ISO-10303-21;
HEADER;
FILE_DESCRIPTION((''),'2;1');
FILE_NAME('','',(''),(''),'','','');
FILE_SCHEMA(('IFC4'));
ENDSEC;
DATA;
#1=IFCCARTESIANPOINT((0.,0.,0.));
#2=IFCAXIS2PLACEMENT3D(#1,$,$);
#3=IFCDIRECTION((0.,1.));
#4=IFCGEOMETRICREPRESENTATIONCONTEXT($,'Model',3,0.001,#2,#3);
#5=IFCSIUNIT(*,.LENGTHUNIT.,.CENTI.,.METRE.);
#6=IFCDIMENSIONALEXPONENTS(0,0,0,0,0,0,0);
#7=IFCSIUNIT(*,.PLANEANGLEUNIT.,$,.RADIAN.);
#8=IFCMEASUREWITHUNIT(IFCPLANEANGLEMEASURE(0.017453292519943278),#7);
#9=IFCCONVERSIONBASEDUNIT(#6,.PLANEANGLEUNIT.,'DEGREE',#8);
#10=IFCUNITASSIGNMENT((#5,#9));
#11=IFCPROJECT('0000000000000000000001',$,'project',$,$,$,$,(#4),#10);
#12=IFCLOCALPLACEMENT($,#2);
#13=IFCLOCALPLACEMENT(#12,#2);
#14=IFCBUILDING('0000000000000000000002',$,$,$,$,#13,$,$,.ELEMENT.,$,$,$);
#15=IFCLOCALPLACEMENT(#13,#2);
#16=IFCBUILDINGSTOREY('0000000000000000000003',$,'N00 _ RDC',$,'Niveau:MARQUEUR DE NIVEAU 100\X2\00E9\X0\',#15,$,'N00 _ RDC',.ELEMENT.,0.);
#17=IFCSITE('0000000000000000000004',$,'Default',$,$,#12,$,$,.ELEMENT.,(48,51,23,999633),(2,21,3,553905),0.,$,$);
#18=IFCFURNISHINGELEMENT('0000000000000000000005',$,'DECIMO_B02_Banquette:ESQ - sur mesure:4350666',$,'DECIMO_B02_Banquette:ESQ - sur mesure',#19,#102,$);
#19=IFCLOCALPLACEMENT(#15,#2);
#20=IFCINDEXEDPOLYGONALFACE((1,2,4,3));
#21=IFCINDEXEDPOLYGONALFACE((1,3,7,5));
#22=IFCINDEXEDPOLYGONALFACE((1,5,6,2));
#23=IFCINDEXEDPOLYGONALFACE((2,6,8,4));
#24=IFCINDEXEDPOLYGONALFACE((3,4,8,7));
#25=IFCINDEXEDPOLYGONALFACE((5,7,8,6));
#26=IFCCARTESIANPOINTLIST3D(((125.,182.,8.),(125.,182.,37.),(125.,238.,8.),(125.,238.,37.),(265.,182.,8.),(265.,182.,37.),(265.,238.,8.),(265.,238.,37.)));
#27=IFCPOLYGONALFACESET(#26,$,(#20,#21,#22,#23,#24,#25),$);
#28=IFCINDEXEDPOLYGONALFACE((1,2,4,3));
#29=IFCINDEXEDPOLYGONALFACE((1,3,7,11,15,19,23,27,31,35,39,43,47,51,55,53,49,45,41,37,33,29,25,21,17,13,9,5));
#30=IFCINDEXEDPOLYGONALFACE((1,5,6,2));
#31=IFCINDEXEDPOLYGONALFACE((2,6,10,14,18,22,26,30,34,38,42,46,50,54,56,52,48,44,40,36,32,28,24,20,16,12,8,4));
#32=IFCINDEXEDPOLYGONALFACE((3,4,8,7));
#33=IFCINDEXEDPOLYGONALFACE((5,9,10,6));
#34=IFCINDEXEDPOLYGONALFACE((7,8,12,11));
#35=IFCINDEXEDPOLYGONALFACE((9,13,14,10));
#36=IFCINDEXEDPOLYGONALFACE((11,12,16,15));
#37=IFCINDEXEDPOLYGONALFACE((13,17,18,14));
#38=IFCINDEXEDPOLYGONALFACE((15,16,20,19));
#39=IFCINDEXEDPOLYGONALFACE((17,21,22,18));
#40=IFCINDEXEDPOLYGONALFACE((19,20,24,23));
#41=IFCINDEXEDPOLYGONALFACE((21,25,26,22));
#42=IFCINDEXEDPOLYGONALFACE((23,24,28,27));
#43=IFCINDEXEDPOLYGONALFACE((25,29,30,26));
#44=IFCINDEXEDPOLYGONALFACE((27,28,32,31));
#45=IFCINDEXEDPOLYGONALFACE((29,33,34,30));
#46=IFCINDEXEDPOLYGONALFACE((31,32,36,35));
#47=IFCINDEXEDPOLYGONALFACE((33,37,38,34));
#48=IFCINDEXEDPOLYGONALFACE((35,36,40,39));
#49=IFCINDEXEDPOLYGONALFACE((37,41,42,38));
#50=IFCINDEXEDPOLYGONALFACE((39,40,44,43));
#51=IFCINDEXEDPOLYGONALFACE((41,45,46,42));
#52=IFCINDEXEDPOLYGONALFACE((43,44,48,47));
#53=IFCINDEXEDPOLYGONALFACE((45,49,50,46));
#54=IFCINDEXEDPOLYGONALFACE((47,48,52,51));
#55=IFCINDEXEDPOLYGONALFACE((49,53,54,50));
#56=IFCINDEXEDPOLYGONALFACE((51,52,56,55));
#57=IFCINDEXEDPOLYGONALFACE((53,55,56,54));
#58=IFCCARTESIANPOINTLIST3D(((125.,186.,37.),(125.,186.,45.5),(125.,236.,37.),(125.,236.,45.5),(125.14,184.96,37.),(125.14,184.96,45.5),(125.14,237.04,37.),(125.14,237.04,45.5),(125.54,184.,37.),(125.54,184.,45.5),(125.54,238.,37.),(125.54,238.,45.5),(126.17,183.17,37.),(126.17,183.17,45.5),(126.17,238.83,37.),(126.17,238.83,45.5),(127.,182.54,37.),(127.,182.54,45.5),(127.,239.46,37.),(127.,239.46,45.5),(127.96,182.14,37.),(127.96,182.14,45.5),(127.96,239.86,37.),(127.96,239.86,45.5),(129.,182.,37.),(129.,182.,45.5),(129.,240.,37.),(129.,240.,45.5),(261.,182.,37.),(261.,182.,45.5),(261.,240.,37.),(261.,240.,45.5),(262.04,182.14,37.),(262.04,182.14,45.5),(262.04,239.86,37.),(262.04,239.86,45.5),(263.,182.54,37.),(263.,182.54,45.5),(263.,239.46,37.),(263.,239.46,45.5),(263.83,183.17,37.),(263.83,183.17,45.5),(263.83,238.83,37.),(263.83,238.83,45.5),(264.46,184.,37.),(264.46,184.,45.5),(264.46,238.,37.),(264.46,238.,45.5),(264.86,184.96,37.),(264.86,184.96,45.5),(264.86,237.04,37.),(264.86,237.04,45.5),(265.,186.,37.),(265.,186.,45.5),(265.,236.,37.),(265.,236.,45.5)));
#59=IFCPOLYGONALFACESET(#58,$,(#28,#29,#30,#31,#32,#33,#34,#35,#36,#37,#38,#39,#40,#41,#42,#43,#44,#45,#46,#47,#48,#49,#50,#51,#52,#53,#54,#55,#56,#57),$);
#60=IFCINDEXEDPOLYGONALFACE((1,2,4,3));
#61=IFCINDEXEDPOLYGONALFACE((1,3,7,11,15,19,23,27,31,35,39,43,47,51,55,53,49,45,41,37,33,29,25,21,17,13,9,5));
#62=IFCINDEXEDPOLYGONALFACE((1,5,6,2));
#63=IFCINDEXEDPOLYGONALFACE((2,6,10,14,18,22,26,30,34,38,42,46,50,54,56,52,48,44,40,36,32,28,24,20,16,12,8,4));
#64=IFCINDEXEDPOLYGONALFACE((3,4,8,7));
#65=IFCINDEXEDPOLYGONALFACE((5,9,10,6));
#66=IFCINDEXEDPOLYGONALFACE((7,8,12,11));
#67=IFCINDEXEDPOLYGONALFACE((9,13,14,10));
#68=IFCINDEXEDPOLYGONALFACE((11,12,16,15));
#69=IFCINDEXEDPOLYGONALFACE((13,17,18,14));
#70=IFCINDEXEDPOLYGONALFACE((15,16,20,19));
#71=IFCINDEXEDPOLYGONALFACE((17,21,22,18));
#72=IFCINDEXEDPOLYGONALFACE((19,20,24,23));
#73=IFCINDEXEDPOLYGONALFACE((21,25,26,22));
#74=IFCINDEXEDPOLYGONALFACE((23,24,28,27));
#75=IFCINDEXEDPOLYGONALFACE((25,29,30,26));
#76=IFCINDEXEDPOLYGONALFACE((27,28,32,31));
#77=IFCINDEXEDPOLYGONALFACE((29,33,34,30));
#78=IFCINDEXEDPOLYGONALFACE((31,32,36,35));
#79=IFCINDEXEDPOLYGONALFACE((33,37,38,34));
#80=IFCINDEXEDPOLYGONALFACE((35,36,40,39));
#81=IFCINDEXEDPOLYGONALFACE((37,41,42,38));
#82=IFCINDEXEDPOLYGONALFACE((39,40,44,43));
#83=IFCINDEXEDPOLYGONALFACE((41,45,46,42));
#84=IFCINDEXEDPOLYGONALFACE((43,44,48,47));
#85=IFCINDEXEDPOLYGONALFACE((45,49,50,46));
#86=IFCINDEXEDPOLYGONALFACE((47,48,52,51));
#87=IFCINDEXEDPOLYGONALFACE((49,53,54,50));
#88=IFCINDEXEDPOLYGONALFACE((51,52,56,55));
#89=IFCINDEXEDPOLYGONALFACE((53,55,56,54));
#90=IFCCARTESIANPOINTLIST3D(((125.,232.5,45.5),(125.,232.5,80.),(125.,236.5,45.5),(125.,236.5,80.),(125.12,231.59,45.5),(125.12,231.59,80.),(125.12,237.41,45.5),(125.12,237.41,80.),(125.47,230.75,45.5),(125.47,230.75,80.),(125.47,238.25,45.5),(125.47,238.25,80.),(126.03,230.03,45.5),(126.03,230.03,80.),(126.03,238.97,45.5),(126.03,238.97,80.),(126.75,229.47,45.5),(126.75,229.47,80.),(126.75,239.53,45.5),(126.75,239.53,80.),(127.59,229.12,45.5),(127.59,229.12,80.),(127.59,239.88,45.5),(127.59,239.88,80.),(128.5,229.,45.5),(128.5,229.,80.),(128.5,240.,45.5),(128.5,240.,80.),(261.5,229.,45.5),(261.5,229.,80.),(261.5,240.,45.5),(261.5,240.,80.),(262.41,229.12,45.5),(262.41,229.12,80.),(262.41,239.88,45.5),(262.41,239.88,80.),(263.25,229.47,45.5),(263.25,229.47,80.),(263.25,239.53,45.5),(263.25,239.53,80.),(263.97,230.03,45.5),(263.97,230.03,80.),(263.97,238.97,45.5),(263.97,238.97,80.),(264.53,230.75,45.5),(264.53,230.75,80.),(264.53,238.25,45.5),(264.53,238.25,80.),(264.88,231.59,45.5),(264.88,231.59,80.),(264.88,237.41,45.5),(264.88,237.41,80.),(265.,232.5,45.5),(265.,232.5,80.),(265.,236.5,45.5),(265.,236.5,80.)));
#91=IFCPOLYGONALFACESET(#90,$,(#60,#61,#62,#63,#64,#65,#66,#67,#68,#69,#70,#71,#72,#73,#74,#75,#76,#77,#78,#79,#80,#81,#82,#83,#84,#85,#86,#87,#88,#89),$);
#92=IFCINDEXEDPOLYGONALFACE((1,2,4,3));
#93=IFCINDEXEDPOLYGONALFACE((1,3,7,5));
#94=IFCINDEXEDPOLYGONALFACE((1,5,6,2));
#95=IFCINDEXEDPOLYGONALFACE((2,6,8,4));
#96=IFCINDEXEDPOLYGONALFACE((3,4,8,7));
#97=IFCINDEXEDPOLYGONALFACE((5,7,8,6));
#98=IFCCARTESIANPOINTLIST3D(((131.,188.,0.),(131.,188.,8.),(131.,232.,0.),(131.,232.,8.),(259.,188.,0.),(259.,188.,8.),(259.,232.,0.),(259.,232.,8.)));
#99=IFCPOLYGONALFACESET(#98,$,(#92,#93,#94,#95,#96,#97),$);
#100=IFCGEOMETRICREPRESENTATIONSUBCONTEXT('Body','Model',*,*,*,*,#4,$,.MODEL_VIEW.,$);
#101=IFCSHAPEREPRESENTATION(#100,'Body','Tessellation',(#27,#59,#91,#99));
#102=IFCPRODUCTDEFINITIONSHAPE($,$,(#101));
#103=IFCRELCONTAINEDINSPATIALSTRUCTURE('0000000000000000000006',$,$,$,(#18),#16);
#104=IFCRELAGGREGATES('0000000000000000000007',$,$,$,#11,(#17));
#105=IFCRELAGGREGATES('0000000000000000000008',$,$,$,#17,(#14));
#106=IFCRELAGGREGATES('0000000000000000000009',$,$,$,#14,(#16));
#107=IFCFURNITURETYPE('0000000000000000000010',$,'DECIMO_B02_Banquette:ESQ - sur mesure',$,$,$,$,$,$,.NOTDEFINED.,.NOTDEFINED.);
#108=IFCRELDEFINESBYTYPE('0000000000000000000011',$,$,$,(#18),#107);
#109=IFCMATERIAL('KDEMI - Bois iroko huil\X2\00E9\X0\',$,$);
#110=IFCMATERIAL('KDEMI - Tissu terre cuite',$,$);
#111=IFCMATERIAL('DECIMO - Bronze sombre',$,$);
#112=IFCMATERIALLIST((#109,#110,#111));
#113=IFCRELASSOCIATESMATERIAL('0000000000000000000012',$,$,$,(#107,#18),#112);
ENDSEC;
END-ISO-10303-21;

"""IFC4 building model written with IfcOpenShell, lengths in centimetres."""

from ifc_helpers import new_model, entity, si_unit, converted_unit, direction, frame, frame_2d, origin, origin_2d_with_axis, place, context, subcontext, project, spatial, polyline, circle_curve, parameter, trimmed, segment, composite_curve, rectangle, outline, extrude, source, transform, mapped, material, material_list, type_object, type_shapes, element, save


model = new_model("IFC4")

# Units and contexts
model_context = context("Model", 3, precision=0.001, world=origin(), true_north=direction((0.0, 1.0)))
body_context = subcontext(model_context, "Body", "Model", "MODEL_VIEW")
ifc_project = project(units=[si_unit("LENGTHUNIT", "METRE", prefix="CENTI"), converted_unit("PLANEANGLEUNIT", "DEGREE", entity("IfcPlaneAngleMeasure", 0.017453292519943278), si_unit("PLANEANGLEUNIT", "RADIAN"), dimensions=[0, 0, 0, 0, 0, 0, 0])], contexts=[model_context])

# Site, building, storey
site_placement = place(None, origin())
site = spatial("IfcSite", under=ifc_project, at=site_placement, Name="Default", CompositionType="ELEMENT", RefLatitude=(48, 51, 23, 999633), RefLongitude=(2, 21, 3, 553905), RefElevation=0.0)
building_placement = place(site_placement, origin())
building = spatial("IfcBuilding", under=site, at=building_placement, CompositionType="ELEMENT")
storey_placement = place(building_placement, origin())
storey = spatial("IfcBuildingStorey", under=building, at=storey_placement, Name="N00 _ RDC", ObjectType="Niveau:MARQUEUR DE NIVEAU 100é", LongName="N00 _ RDC", CompositionType="ELEMENT", Elevation=0.0)

# Furnishing element
ifc_material_1 = material(Name="KDEMI - Bois iroko huilé")
ifc_material_2 = material(Name="DECIMO - Bronze sombre")
ifc_material_3 = material(Name="KDEMI - Tissu terre cuite")
ifc_material_list_1 = material_list([ifc_material_1, ifc_material_3, ifc_material_2])
furniture_type_1 = type_object("IfcFurnitureType", Name="DECIMO_B02_Banquette:ESQ - sur mesure", AssemblyPlace="NOTDEFINED", material=ifc_material_list_1)
shared_shape_1 = source(origin(), body_context, "Body", "SweptSolid", [
    extrude(rectangle(XDim=140.0, YDim=56.0, at=origin_2d_with_axis()), frame((70.0, 28.0, 8.0)), (0.0, 0.0, 1.0), 29.0),
    extrude(outline(composite_curve([segment(polyline([(-66.0, -29.0), (66.0, -29.0)]), True, "CONTINUOUS"), segment(trimmed(circle_curve(frame_2d((66.0, -25.0), x_axis=(1.0, 0.0)), 4.0), [parameter(270.0)], [parameter(0.0)], True, "PARAMETER"), True, "CONTINUOUS"), segment(polyline([(70.0, -25.0), (70.0, 25.0)]), True, "CONTINUOUS"), segment(trimmed(circle_curve(frame_2d((66.0, 25.0), x_axis=(1.0, 0.0)), 4.0), [parameter(0.0)], [parameter(90.0)], True, "PARAMETER"), True, "CONTINUOUS"), segment(polyline([(66.0, 29.0), (-66.0, 29.0)]), True, "CONTINUOUS"), segment(trimmed(circle_curve(frame_2d((-66.0, 25.0), x_axis=(1.0, 0.0)), 4.0), [parameter(90.0)], [parameter(180.0)], True, "PARAMETER"), True, "CONTINUOUS"), segment(polyline([(-70.0, 25.0), (-70.0, -25.0)]), True, "CONTINUOUS"), segment(trimmed(circle_curve(frame_2d((-66.0, -25.0), x_axis=(1.0, 0.0)), 4.0), [parameter(180.0)], [parameter(270.0)], True, "PARAMETER"), True, "CONTINUOUS")], self_intersect=False)), frame((70.0, 29.0, 37.0)), (0.0, 0.0, 1.0), 8.5),
    extrude(outline(composite_curve([segment(polyline([(-66.5, -5.5), (66.5, -5.5)]), True, "CONTINUOUS"), segment(trimmed(circle_curve(frame_2d((66.5, -2.0), x_axis=(1.0, 0.0)), 3.5), [parameter(270.0)], [parameter(0.0)], True, "PARAMETER"), True, "CONTINUOUS"), segment(polyline([(70.0, -2.0), (70.0, 2.0)]), True, "CONTINUOUS"), segment(trimmed(circle_curve(frame_2d((66.5, 2.0), x_axis=(1.0, 0.0)), 3.5), [parameter(0.0)], [parameter(90.0)], True, "PARAMETER"), True, "CONTINUOUS"), segment(polyline([(66.5, 5.5), (-66.5, 5.5)]), True, "CONTINUOUS"), segment(trimmed(circle_curve(frame_2d((-66.5, 2.0), x_axis=(1.0, 0.0)), 3.5), [parameter(90.0)], [parameter(180.0)], True, "PARAMETER"), True, "CONTINUOUS"), segment(polyline([(-70.0, 2.0), (-70.0, -2.0)]), True, "CONTINUOUS"), segment(trimmed(circle_curve(frame_2d((-66.5, -2.0), x_axis=(1.0, 0.0)), 3.5), [parameter(180.0)], [parameter(270.0)], True, "PARAMETER"), True, "CONTINUOUS")], self_intersect=False)), frame((70.0, 52.5, 45.5)), (0.0, 0.0, 1.0), 34.5),
    extrude(rectangle(XDim=128.0, YDim=44.0, at=frame_2d((0.0, 0.0), x_axis=(1.0, 0.0))), frame((70.0, 28.0, 0.0)), (0.0, 0.0, 1.0), 8.0),
])
type_shapes(furniture_type_1, [shared_shape_1])
furnishing_1_placement = place(storey_placement, frame((125.0, 182.0, 0.0)))
element("IfcFurnishingElement", 1, at=furnishing_1_placement, inside=storey, type_object=furniture_type_1, material=ifc_material_list_1, Name="DECIMO_B02_Banquette:ESQ - sur mesure:4350666", ObjectType="DECIMO_B02_Banquette:ESQ - sur mesure", context=body_context, shape_type="MappedRepresentation", body=[
    mapped(shared_shape_1, transform((0.0, 0.0, 0.0), scale=1.0)),
])

save(model, "model.ifc")
